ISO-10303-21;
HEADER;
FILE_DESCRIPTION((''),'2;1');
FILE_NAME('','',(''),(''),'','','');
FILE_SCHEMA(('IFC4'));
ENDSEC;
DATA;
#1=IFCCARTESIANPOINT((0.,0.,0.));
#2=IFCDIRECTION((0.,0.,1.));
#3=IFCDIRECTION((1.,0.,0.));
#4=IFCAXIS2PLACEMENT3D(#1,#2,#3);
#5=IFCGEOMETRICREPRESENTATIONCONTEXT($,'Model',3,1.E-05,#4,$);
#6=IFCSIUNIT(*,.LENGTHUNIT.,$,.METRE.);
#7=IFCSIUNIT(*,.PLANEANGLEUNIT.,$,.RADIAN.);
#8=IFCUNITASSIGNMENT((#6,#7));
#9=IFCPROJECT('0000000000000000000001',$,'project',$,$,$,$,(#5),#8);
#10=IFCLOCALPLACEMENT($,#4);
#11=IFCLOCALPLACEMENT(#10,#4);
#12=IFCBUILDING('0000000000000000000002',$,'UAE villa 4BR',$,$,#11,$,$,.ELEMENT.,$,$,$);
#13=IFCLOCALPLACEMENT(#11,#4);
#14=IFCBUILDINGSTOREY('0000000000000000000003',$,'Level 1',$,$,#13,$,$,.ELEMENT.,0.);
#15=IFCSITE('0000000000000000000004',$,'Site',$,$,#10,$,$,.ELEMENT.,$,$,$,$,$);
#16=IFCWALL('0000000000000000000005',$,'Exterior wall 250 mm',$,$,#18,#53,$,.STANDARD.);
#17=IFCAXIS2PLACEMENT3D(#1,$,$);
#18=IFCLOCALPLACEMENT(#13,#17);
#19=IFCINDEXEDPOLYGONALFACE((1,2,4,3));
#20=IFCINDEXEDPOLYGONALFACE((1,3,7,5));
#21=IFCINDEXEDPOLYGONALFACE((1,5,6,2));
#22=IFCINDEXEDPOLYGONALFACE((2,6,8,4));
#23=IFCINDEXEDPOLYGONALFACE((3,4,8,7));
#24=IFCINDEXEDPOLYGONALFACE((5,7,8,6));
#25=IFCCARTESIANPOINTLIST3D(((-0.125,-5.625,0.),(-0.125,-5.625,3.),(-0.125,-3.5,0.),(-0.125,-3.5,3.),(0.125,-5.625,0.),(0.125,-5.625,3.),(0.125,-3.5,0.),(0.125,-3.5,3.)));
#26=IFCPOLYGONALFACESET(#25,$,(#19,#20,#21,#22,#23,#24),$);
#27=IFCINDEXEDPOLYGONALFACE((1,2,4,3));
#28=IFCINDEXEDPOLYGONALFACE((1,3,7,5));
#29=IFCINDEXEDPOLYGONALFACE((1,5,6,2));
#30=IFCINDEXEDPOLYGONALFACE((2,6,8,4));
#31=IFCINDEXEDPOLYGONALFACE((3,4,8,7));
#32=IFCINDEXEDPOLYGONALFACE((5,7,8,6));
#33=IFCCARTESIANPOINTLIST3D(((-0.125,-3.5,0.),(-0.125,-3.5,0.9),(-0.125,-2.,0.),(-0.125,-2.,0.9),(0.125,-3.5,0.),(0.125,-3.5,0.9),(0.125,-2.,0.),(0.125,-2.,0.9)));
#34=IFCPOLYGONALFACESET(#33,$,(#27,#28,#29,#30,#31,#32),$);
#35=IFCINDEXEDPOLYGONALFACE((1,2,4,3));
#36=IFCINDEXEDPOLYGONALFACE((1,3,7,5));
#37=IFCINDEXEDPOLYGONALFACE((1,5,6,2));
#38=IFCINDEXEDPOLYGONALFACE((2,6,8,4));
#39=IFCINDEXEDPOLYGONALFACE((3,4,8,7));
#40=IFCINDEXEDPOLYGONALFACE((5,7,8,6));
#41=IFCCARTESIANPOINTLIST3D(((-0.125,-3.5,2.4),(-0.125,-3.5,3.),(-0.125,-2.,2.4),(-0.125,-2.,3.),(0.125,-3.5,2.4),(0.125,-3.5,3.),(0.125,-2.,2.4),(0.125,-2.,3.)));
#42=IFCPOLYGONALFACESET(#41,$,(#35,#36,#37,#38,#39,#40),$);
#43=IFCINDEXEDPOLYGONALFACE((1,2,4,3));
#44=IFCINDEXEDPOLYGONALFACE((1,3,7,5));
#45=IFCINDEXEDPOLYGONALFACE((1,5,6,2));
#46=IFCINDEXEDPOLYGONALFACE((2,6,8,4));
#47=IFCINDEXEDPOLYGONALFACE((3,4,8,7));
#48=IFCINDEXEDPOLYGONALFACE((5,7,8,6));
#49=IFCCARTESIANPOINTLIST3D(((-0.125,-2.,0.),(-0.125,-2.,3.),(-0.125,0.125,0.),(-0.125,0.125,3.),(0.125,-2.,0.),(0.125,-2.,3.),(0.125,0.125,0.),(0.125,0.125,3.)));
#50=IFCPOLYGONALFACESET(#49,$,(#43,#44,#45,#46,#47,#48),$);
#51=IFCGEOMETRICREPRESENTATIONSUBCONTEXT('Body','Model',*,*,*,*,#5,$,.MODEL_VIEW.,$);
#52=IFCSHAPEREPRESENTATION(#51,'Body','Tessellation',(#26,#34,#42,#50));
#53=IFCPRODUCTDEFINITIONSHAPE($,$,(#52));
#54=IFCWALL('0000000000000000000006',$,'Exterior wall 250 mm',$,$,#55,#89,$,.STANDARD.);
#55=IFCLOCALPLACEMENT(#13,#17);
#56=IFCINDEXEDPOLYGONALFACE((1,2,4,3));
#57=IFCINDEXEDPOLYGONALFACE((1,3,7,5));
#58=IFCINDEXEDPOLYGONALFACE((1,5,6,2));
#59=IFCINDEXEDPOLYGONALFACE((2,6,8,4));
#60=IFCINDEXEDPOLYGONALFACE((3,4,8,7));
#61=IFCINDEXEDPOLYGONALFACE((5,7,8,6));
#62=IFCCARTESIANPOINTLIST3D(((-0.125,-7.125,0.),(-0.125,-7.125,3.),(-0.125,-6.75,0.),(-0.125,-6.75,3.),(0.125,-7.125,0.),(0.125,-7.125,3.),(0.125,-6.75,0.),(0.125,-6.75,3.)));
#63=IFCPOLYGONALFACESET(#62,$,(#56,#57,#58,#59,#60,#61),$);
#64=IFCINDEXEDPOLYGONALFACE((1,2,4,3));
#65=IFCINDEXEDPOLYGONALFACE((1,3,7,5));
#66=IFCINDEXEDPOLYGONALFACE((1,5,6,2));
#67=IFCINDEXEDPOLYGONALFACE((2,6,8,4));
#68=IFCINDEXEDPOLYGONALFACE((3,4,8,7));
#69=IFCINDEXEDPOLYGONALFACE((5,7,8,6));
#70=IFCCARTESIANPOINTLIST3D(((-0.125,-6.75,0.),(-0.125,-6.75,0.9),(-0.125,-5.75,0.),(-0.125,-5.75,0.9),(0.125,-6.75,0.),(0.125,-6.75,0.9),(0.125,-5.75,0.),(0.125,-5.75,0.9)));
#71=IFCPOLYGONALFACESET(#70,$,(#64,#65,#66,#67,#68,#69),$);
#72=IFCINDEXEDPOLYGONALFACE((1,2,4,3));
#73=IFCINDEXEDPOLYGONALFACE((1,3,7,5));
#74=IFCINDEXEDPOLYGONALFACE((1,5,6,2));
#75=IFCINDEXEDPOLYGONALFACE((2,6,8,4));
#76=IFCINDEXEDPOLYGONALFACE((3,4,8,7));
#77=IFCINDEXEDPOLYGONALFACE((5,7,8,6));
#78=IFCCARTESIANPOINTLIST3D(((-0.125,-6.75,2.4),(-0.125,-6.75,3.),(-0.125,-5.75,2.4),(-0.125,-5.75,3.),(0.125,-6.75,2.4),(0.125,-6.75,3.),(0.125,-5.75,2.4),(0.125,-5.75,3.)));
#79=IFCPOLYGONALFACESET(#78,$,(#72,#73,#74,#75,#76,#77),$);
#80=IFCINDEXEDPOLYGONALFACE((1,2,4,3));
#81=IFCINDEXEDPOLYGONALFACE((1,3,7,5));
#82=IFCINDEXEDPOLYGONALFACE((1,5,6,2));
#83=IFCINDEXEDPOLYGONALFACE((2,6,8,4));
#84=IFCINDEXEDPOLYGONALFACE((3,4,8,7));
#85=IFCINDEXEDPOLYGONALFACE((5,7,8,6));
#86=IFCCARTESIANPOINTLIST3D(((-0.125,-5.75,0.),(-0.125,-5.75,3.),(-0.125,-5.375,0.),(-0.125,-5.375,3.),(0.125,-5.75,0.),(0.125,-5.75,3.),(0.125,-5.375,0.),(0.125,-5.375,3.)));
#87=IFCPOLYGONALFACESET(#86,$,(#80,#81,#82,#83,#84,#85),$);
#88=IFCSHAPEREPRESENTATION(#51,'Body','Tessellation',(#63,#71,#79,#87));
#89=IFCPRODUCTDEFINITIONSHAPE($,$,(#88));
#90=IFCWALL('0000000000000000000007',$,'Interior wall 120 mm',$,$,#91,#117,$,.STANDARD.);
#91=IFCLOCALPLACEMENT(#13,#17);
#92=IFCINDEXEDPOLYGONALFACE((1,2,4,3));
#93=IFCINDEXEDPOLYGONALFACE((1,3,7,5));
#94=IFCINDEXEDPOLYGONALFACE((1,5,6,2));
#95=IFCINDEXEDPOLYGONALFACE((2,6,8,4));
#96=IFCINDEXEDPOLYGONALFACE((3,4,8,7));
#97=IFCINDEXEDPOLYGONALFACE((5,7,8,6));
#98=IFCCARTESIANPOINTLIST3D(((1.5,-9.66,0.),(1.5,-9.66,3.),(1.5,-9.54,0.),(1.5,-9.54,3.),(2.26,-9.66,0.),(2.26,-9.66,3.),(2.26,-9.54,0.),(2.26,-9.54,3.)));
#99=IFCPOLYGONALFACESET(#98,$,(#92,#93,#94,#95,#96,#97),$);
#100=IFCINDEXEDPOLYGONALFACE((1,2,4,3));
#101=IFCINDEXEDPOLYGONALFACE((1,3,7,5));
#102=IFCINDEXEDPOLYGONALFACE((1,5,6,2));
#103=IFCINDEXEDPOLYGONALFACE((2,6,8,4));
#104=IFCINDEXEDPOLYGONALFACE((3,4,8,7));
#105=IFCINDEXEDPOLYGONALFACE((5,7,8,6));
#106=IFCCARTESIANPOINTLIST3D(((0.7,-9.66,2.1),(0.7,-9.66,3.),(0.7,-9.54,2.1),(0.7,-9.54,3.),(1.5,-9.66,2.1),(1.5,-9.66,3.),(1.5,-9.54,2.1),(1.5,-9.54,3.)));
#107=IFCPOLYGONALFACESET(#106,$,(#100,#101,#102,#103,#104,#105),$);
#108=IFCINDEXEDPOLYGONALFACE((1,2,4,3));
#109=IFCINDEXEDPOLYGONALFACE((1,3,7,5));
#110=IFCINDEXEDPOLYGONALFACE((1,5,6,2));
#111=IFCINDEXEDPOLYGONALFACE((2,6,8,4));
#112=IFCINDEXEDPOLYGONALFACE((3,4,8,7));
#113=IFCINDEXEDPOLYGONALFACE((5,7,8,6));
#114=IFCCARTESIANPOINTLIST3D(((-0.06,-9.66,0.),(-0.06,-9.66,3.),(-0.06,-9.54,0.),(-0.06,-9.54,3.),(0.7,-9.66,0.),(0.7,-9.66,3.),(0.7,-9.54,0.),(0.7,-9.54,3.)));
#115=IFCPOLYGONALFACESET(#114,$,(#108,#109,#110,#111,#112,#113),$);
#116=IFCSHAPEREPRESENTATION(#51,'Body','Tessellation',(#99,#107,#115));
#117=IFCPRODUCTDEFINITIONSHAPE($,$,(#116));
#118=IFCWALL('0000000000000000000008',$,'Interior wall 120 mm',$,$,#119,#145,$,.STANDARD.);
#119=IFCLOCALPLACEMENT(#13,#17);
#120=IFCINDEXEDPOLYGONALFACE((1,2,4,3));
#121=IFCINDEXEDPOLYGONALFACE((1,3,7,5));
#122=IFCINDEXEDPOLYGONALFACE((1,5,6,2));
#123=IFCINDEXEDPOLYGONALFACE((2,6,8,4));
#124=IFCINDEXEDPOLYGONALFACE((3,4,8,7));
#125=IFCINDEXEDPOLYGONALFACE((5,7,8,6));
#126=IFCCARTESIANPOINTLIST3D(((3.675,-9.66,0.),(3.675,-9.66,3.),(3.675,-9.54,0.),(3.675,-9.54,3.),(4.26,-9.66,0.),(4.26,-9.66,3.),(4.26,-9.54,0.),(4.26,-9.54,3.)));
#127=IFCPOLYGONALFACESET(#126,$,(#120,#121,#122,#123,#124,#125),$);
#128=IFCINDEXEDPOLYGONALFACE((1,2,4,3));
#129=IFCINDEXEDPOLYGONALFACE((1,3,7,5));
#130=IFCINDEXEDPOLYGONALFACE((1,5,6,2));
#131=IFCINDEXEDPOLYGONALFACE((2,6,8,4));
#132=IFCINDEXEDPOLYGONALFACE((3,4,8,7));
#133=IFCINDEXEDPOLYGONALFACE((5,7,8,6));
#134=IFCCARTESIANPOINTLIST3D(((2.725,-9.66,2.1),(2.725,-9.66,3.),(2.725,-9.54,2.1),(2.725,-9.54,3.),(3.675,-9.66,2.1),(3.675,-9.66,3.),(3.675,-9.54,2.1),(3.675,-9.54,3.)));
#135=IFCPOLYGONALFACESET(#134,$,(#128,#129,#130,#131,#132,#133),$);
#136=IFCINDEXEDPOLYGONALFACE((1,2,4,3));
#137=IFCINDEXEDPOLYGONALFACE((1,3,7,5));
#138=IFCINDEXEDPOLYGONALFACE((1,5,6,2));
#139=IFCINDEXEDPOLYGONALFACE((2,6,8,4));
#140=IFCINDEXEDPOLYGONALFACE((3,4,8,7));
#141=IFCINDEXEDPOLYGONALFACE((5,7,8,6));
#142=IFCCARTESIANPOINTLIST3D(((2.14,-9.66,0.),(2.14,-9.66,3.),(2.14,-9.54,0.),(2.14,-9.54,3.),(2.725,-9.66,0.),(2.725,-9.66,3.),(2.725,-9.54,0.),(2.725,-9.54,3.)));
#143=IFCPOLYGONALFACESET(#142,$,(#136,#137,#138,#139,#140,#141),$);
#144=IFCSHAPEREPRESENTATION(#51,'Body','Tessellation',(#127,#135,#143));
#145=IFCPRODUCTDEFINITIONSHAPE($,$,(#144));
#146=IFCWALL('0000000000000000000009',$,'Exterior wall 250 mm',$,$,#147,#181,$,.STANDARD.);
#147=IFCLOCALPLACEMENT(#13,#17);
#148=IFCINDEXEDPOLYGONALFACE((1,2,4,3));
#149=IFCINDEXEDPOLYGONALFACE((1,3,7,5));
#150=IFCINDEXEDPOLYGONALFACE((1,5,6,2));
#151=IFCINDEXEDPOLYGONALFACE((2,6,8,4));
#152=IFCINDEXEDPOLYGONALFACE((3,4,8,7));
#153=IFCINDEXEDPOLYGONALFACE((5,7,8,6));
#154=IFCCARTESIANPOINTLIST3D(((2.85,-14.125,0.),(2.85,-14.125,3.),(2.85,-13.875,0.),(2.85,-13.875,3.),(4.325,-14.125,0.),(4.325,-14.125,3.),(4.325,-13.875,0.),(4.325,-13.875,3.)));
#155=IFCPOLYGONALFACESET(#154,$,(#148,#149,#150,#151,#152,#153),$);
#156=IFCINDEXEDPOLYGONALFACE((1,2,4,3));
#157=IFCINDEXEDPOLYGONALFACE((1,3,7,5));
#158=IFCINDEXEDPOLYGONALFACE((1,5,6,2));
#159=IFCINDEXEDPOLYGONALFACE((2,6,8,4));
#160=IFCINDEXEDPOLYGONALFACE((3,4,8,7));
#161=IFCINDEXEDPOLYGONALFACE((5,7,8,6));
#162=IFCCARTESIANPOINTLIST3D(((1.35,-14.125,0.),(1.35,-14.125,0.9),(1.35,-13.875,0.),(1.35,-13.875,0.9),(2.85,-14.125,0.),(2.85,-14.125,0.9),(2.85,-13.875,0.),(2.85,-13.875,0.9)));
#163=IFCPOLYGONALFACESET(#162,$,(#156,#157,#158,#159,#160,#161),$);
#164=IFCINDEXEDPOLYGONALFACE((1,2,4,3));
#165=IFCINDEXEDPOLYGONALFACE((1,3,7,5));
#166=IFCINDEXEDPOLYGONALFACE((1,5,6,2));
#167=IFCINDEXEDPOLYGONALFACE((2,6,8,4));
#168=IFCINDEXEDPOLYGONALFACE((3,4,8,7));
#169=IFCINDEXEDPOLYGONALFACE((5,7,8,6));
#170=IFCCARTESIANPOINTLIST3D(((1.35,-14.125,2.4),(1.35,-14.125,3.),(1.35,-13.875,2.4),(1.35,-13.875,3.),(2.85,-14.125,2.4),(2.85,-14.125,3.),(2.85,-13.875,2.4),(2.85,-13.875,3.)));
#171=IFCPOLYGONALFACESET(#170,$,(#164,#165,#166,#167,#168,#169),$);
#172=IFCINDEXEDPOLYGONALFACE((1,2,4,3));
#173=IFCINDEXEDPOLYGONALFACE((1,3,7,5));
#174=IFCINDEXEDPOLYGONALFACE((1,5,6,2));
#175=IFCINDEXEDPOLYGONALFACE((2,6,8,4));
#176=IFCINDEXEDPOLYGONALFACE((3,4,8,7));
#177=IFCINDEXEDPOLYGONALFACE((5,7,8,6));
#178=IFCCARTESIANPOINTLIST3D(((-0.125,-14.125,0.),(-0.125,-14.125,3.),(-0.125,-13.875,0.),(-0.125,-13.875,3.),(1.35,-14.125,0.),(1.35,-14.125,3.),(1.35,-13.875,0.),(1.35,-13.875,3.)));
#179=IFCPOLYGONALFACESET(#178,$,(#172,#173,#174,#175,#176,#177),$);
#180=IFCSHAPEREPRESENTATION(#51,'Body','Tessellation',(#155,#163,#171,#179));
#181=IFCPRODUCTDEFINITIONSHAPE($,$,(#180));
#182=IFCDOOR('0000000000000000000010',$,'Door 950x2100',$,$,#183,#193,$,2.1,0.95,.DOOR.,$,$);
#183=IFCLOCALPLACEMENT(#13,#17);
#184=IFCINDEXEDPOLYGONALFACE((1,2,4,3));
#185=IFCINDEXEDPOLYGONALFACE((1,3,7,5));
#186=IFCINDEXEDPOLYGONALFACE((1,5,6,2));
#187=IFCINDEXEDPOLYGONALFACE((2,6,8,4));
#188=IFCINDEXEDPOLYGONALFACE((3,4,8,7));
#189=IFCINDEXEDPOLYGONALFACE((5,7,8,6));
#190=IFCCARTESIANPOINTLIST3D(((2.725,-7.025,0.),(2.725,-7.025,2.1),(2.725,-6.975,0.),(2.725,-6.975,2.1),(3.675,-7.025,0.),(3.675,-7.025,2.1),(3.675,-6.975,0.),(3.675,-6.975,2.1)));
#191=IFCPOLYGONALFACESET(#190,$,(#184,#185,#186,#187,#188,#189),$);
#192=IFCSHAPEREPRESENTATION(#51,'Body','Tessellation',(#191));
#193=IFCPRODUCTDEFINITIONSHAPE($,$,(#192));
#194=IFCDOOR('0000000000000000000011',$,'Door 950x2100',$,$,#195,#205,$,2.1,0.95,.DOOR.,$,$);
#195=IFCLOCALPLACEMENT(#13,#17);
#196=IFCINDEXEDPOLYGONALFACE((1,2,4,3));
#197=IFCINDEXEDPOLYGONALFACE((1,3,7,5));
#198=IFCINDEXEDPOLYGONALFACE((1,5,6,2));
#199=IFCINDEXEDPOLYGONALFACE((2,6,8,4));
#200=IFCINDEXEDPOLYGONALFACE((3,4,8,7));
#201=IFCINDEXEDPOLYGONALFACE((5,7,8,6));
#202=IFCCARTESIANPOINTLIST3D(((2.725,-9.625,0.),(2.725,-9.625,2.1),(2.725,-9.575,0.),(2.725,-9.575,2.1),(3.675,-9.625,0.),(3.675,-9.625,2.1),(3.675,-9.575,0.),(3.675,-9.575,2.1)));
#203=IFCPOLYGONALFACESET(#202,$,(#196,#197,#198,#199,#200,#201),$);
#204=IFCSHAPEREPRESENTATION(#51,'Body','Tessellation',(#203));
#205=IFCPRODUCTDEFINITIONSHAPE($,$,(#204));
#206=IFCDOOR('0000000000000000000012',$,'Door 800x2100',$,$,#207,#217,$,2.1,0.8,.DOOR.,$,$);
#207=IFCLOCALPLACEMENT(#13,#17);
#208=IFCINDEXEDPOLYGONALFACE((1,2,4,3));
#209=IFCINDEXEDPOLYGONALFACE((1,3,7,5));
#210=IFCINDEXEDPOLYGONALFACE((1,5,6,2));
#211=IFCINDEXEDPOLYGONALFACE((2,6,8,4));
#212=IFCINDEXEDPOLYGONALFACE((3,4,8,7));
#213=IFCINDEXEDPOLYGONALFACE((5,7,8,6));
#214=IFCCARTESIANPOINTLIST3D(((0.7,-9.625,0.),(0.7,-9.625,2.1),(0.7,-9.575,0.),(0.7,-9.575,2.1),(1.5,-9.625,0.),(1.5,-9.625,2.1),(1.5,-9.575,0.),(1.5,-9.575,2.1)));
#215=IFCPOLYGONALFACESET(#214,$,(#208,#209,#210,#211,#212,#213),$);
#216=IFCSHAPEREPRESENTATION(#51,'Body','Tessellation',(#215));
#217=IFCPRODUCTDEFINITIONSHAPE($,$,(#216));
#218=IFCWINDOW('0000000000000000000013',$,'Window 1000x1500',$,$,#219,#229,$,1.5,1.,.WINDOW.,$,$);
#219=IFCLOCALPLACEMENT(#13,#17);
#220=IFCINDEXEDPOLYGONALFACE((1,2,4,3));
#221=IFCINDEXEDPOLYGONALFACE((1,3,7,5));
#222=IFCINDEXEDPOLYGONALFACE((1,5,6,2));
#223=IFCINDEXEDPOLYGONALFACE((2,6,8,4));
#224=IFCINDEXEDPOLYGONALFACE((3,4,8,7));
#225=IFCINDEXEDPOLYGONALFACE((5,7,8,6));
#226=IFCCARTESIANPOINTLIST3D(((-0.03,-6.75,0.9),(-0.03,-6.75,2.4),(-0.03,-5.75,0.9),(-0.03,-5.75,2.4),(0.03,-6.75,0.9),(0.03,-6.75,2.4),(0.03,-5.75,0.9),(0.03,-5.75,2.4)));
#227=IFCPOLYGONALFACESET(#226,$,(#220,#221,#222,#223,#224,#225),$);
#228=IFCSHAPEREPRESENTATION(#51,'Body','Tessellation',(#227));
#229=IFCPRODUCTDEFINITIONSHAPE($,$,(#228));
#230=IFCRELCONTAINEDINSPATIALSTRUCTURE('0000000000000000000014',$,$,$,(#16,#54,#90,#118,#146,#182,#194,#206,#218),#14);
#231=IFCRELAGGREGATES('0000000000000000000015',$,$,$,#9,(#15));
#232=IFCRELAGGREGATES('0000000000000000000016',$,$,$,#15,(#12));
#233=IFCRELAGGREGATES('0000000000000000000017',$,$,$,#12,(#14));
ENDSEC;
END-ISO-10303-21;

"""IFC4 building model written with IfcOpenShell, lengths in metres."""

from ifc_helpers import new_model, si_unit, frame, origin, origin_with_axes, origin_2d, place, context, subcontext, project, spatial, rectangle, extrude, element, save


model = new_model("IFC4")

# Units and contexts
model_context = context("Model", 3, precision=1e-05, world=origin_with_axes())
body_context = subcontext(model_context, "Body", "Model", "MODEL_VIEW")
ifc_project = project(units=[si_unit("LENGTHUNIT", "METRE"), si_unit("PLANEANGLEUNIT", "RADIAN")], contexts=[model_context])

# Site, building, storey
site_placement = place(None, origin_with_axes())
site = spatial("IfcSite", under=ifc_project, at=site_placement, Name="Site", CompositionType="ELEMENT")
building_placement = place(site_placement, origin_with_axes())
building = spatial("IfcBuilding", under=site, at=building_placement, Name="UAE villa 4BR", CompositionType="ELEMENT")
storey_placement = place(building_placement, origin_with_axes())
storey = spatial("IfcBuildingStorey", under=building, at=storey_placement, Name="Level 1", CompositionType="ELEMENT", Elevation=0.0)

# Walls
wall_1_placement = place(storey_placement, frame((0.0, -5.5, 0.0), z_axis=(0.0, 0.0, 1.0), x_axis=(0.0, 1.0, 0.0)))
element("IfcWall", 1, at=wall_1_placement, inside=storey, Name="Exterior wall 250 mm", PredefinedType="STANDARD", context=body_context, shape_type="SweptSolid", body=[
    extrude(rectangle(XDim=2.125, YDim=0.25, at=origin_2d()), frame((0.9375, 0.0, 0.0)), (0.0, 0.0, 1.0), 3.0),
    extrude(rectangle(XDim=1.5, YDim=0.25, at=origin_2d()), frame((2.75, 0.0, 0.0)), (0.0, 0.0, 1.0), 0.9),
    extrude(rectangle(XDim=1.5, YDim=0.25, at=origin_2d()), frame((2.75, 0.0, 2.4)), (0.0, 0.0, 1.0), 0.6),
    extrude(rectangle(XDim=2.125, YDim=0.25, at=origin_2d()), frame((4.5625, 0.0, 0.0)), (0.0, 0.0, 1.0), 3.0),
])
wall_2_placement = place(storey_placement, frame((0.0, -7.0, 0.0), z_axis=(0.0, 0.0, 1.0), x_axis=(0.0, 1.0, 0.0)))
element("IfcWall", 2, at=wall_2_placement, inside=storey, Name="Exterior wall 250 mm", PredefinedType="STANDARD", context=body_context, shape_type="SweptSolid", body=[
    extrude(rectangle(XDim=0.375, YDim=0.25, at=origin_2d()), frame((0.0625, 0.0, 0.0)), (0.0, 0.0, 1.0), 3.0),
    extrude(rectangle(XDim=1.0, YDim=0.25, at=origin_2d()), frame((0.75, 0.0, 0.0)), (0.0, 0.0, 1.0), 0.9),
    extrude(rectangle(XDim=1.0, YDim=0.25, at=origin_2d()), frame((0.75, 0.0, 2.4)), (0.0, 0.0, 1.0), 0.6),
    extrude(rectangle(XDim=0.375, YDim=0.25, at=origin_2d()), frame((1.4375, 0.0, 0.0)), (0.0, 0.0, 1.0), 3.0),
])
wall_3_placement = place(storey_placement, frame((2.2, -9.6, 0.0), z_axis=(0.0, 0.0, 1.0), x_axis=(-1.0, 0.0, 0.0)))
element("IfcWall", 3, at=wall_3_placement, inside=storey, Name="Interior wall 120 mm", PredefinedType="STANDARD", context=body_context, shape_type="SweptSolid", body=[
    extrude(rectangle(XDim=0.76, YDim=0.12, at=origin_2d()), frame((0.32, 0.0, 0.0)), (0.0, 0.0, 1.0), 3.0),
    extrude(rectangle(XDim=0.8, YDim=0.12, at=origin_2d()), frame((1.1, 0.0, 2.1)), (0.0, 0.0, 1.0), 0.9),
    extrude(rectangle(XDim=0.76, YDim=0.12, at=origin_2d()), frame((1.88, 0.0, 0.0)), (0.0, 0.0, 1.0), 3.0),
])
wall_4_placement = place(storey_placement, frame((4.2, -9.6, 0.0), z_axis=(0.0, 0.0, 1.0), x_axis=(-1.0, 0.0, 0.0)))
element("IfcWall", 4, at=wall_4_placement, inside=storey, Name="Interior wall 120 mm", PredefinedType="STANDARD", context=body_context, shape_type="SweptSolid", body=[
    extrude(rectangle(XDim=0.585, YDim=0.12, at=origin_2d()), frame((0.2325, 0.0, 0.0)), (0.0, 0.0, 1.0), 3.0),
    extrude(rectangle(XDim=0.95, YDim=0.12, at=origin_2d()), frame((1.0, 0.0, 2.1)), (0.0, 0.0, 1.0), 0.9),
    extrude(rectangle(XDim=0.585, YDim=0.12, at=origin_2d()), frame((1.7675, 0.0, 0.0)), (0.0, 0.0, 1.0), 3.0),
])
wall_5_placement = place(storey_placement, frame((4.2, -14.0, 0.0), z_axis=(0.0, 0.0, 1.0), x_axis=(-1.0, 0.0, 0.0)))
element("IfcWall", 5, at=wall_5_placement, inside=storey, Name="Exterior wall 250 mm", PredefinedType="STANDARD", context=body_context, shape_type="SweptSolid", body=[
    extrude(rectangle(XDim=1.475, YDim=0.25, at=origin_2d()), frame((0.6125, 0.0, 0.0)), (0.0, 0.0, 1.0), 3.0),
    extrude(rectangle(XDim=1.5, YDim=0.25, at=origin_2d()), frame((2.1, 0.0, 0.0)), (0.0, 0.0, 1.0), 0.9),
    extrude(rectangle(XDim=1.5, YDim=0.25, at=origin_2d()), frame((2.1, 0.0, 2.4)), (0.0, 0.0, 1.0), 0.6),
    extrude(rectangle(XDim=1.475, YDim=0.25, at=origin_2d()), frame((3.5875, 0.0, 0.0)), (0.0, 0.0, 1.0), 3.0),
])

# Doors
for number, where, z_axis, x_axis, name in (
    (6, (3.2, -7.0, 0.0), (0.0, 0.0, 1.0), (-1.0, 0.0, 0.0), "Door 950x2100"),
    (7, (3.2, -9.6, 0.0), (0.0, 0.0, 1.0), (-1.0, 0.0, 0.0), "Door 950x2100"),
):
    element("IfcDoor", number, at=place(storey_placement, frame(where, z_axis=z_axis, x_axis=x_axis)), inside=storey, Name=name, OverallHeight=2.1, OverallWidth=0.95, PredefinedType="DOOR", context=body_context, shape_type="SweptSolid", body=[
        extrude(rectangle(XDim=0.95, YDim=0.05, at=origin_2d()), origin(), (0.0, 0.0, 1.0), 2.1),
    ])
door_placement = place(storey_placement, frame((1.1, -9.6, 0.0), z_axis=(0.0, 0.0, 1.0), x_axis=(-1.0, 0.0, 0.0)))
element("IfcDoor", 8, at=door_placement, inside=storey, Name="Door 800x2100", OverallHeight=2.1, OverallWidth=0.8, PredefinedType="DOOR", context=body_context, shape_type="SweptSolid", body=[
    extrude(rectangle(XDim=0.8, YDim=0.05, at=origin_2d()), origin(), (0.0, 0.0, 1.0), 2.1),
])

# Window
window_1_placement = place(storey_placement, frame((0.0, -6.25, 0.9), z_axis=(0.0, 0.0, 1.0), x_axis=(0.0, 1.0, 0.0)))
element("IfcWindow", 9, at=window_1_placement, inside=storey, Name="Window 1000x1500", OverallHeight=1.5, OverallWidth=1.0, PredefinedType="WINDOW", context=body_context, shape_type="SweptSolid", body=[
    extrude(rectangle(XDim=1.0, YDim=0.06, at=origin_2d()), origin(), (0.0, 0.0, 1.0), 1.5),
])

save(model, "model.ifc")
